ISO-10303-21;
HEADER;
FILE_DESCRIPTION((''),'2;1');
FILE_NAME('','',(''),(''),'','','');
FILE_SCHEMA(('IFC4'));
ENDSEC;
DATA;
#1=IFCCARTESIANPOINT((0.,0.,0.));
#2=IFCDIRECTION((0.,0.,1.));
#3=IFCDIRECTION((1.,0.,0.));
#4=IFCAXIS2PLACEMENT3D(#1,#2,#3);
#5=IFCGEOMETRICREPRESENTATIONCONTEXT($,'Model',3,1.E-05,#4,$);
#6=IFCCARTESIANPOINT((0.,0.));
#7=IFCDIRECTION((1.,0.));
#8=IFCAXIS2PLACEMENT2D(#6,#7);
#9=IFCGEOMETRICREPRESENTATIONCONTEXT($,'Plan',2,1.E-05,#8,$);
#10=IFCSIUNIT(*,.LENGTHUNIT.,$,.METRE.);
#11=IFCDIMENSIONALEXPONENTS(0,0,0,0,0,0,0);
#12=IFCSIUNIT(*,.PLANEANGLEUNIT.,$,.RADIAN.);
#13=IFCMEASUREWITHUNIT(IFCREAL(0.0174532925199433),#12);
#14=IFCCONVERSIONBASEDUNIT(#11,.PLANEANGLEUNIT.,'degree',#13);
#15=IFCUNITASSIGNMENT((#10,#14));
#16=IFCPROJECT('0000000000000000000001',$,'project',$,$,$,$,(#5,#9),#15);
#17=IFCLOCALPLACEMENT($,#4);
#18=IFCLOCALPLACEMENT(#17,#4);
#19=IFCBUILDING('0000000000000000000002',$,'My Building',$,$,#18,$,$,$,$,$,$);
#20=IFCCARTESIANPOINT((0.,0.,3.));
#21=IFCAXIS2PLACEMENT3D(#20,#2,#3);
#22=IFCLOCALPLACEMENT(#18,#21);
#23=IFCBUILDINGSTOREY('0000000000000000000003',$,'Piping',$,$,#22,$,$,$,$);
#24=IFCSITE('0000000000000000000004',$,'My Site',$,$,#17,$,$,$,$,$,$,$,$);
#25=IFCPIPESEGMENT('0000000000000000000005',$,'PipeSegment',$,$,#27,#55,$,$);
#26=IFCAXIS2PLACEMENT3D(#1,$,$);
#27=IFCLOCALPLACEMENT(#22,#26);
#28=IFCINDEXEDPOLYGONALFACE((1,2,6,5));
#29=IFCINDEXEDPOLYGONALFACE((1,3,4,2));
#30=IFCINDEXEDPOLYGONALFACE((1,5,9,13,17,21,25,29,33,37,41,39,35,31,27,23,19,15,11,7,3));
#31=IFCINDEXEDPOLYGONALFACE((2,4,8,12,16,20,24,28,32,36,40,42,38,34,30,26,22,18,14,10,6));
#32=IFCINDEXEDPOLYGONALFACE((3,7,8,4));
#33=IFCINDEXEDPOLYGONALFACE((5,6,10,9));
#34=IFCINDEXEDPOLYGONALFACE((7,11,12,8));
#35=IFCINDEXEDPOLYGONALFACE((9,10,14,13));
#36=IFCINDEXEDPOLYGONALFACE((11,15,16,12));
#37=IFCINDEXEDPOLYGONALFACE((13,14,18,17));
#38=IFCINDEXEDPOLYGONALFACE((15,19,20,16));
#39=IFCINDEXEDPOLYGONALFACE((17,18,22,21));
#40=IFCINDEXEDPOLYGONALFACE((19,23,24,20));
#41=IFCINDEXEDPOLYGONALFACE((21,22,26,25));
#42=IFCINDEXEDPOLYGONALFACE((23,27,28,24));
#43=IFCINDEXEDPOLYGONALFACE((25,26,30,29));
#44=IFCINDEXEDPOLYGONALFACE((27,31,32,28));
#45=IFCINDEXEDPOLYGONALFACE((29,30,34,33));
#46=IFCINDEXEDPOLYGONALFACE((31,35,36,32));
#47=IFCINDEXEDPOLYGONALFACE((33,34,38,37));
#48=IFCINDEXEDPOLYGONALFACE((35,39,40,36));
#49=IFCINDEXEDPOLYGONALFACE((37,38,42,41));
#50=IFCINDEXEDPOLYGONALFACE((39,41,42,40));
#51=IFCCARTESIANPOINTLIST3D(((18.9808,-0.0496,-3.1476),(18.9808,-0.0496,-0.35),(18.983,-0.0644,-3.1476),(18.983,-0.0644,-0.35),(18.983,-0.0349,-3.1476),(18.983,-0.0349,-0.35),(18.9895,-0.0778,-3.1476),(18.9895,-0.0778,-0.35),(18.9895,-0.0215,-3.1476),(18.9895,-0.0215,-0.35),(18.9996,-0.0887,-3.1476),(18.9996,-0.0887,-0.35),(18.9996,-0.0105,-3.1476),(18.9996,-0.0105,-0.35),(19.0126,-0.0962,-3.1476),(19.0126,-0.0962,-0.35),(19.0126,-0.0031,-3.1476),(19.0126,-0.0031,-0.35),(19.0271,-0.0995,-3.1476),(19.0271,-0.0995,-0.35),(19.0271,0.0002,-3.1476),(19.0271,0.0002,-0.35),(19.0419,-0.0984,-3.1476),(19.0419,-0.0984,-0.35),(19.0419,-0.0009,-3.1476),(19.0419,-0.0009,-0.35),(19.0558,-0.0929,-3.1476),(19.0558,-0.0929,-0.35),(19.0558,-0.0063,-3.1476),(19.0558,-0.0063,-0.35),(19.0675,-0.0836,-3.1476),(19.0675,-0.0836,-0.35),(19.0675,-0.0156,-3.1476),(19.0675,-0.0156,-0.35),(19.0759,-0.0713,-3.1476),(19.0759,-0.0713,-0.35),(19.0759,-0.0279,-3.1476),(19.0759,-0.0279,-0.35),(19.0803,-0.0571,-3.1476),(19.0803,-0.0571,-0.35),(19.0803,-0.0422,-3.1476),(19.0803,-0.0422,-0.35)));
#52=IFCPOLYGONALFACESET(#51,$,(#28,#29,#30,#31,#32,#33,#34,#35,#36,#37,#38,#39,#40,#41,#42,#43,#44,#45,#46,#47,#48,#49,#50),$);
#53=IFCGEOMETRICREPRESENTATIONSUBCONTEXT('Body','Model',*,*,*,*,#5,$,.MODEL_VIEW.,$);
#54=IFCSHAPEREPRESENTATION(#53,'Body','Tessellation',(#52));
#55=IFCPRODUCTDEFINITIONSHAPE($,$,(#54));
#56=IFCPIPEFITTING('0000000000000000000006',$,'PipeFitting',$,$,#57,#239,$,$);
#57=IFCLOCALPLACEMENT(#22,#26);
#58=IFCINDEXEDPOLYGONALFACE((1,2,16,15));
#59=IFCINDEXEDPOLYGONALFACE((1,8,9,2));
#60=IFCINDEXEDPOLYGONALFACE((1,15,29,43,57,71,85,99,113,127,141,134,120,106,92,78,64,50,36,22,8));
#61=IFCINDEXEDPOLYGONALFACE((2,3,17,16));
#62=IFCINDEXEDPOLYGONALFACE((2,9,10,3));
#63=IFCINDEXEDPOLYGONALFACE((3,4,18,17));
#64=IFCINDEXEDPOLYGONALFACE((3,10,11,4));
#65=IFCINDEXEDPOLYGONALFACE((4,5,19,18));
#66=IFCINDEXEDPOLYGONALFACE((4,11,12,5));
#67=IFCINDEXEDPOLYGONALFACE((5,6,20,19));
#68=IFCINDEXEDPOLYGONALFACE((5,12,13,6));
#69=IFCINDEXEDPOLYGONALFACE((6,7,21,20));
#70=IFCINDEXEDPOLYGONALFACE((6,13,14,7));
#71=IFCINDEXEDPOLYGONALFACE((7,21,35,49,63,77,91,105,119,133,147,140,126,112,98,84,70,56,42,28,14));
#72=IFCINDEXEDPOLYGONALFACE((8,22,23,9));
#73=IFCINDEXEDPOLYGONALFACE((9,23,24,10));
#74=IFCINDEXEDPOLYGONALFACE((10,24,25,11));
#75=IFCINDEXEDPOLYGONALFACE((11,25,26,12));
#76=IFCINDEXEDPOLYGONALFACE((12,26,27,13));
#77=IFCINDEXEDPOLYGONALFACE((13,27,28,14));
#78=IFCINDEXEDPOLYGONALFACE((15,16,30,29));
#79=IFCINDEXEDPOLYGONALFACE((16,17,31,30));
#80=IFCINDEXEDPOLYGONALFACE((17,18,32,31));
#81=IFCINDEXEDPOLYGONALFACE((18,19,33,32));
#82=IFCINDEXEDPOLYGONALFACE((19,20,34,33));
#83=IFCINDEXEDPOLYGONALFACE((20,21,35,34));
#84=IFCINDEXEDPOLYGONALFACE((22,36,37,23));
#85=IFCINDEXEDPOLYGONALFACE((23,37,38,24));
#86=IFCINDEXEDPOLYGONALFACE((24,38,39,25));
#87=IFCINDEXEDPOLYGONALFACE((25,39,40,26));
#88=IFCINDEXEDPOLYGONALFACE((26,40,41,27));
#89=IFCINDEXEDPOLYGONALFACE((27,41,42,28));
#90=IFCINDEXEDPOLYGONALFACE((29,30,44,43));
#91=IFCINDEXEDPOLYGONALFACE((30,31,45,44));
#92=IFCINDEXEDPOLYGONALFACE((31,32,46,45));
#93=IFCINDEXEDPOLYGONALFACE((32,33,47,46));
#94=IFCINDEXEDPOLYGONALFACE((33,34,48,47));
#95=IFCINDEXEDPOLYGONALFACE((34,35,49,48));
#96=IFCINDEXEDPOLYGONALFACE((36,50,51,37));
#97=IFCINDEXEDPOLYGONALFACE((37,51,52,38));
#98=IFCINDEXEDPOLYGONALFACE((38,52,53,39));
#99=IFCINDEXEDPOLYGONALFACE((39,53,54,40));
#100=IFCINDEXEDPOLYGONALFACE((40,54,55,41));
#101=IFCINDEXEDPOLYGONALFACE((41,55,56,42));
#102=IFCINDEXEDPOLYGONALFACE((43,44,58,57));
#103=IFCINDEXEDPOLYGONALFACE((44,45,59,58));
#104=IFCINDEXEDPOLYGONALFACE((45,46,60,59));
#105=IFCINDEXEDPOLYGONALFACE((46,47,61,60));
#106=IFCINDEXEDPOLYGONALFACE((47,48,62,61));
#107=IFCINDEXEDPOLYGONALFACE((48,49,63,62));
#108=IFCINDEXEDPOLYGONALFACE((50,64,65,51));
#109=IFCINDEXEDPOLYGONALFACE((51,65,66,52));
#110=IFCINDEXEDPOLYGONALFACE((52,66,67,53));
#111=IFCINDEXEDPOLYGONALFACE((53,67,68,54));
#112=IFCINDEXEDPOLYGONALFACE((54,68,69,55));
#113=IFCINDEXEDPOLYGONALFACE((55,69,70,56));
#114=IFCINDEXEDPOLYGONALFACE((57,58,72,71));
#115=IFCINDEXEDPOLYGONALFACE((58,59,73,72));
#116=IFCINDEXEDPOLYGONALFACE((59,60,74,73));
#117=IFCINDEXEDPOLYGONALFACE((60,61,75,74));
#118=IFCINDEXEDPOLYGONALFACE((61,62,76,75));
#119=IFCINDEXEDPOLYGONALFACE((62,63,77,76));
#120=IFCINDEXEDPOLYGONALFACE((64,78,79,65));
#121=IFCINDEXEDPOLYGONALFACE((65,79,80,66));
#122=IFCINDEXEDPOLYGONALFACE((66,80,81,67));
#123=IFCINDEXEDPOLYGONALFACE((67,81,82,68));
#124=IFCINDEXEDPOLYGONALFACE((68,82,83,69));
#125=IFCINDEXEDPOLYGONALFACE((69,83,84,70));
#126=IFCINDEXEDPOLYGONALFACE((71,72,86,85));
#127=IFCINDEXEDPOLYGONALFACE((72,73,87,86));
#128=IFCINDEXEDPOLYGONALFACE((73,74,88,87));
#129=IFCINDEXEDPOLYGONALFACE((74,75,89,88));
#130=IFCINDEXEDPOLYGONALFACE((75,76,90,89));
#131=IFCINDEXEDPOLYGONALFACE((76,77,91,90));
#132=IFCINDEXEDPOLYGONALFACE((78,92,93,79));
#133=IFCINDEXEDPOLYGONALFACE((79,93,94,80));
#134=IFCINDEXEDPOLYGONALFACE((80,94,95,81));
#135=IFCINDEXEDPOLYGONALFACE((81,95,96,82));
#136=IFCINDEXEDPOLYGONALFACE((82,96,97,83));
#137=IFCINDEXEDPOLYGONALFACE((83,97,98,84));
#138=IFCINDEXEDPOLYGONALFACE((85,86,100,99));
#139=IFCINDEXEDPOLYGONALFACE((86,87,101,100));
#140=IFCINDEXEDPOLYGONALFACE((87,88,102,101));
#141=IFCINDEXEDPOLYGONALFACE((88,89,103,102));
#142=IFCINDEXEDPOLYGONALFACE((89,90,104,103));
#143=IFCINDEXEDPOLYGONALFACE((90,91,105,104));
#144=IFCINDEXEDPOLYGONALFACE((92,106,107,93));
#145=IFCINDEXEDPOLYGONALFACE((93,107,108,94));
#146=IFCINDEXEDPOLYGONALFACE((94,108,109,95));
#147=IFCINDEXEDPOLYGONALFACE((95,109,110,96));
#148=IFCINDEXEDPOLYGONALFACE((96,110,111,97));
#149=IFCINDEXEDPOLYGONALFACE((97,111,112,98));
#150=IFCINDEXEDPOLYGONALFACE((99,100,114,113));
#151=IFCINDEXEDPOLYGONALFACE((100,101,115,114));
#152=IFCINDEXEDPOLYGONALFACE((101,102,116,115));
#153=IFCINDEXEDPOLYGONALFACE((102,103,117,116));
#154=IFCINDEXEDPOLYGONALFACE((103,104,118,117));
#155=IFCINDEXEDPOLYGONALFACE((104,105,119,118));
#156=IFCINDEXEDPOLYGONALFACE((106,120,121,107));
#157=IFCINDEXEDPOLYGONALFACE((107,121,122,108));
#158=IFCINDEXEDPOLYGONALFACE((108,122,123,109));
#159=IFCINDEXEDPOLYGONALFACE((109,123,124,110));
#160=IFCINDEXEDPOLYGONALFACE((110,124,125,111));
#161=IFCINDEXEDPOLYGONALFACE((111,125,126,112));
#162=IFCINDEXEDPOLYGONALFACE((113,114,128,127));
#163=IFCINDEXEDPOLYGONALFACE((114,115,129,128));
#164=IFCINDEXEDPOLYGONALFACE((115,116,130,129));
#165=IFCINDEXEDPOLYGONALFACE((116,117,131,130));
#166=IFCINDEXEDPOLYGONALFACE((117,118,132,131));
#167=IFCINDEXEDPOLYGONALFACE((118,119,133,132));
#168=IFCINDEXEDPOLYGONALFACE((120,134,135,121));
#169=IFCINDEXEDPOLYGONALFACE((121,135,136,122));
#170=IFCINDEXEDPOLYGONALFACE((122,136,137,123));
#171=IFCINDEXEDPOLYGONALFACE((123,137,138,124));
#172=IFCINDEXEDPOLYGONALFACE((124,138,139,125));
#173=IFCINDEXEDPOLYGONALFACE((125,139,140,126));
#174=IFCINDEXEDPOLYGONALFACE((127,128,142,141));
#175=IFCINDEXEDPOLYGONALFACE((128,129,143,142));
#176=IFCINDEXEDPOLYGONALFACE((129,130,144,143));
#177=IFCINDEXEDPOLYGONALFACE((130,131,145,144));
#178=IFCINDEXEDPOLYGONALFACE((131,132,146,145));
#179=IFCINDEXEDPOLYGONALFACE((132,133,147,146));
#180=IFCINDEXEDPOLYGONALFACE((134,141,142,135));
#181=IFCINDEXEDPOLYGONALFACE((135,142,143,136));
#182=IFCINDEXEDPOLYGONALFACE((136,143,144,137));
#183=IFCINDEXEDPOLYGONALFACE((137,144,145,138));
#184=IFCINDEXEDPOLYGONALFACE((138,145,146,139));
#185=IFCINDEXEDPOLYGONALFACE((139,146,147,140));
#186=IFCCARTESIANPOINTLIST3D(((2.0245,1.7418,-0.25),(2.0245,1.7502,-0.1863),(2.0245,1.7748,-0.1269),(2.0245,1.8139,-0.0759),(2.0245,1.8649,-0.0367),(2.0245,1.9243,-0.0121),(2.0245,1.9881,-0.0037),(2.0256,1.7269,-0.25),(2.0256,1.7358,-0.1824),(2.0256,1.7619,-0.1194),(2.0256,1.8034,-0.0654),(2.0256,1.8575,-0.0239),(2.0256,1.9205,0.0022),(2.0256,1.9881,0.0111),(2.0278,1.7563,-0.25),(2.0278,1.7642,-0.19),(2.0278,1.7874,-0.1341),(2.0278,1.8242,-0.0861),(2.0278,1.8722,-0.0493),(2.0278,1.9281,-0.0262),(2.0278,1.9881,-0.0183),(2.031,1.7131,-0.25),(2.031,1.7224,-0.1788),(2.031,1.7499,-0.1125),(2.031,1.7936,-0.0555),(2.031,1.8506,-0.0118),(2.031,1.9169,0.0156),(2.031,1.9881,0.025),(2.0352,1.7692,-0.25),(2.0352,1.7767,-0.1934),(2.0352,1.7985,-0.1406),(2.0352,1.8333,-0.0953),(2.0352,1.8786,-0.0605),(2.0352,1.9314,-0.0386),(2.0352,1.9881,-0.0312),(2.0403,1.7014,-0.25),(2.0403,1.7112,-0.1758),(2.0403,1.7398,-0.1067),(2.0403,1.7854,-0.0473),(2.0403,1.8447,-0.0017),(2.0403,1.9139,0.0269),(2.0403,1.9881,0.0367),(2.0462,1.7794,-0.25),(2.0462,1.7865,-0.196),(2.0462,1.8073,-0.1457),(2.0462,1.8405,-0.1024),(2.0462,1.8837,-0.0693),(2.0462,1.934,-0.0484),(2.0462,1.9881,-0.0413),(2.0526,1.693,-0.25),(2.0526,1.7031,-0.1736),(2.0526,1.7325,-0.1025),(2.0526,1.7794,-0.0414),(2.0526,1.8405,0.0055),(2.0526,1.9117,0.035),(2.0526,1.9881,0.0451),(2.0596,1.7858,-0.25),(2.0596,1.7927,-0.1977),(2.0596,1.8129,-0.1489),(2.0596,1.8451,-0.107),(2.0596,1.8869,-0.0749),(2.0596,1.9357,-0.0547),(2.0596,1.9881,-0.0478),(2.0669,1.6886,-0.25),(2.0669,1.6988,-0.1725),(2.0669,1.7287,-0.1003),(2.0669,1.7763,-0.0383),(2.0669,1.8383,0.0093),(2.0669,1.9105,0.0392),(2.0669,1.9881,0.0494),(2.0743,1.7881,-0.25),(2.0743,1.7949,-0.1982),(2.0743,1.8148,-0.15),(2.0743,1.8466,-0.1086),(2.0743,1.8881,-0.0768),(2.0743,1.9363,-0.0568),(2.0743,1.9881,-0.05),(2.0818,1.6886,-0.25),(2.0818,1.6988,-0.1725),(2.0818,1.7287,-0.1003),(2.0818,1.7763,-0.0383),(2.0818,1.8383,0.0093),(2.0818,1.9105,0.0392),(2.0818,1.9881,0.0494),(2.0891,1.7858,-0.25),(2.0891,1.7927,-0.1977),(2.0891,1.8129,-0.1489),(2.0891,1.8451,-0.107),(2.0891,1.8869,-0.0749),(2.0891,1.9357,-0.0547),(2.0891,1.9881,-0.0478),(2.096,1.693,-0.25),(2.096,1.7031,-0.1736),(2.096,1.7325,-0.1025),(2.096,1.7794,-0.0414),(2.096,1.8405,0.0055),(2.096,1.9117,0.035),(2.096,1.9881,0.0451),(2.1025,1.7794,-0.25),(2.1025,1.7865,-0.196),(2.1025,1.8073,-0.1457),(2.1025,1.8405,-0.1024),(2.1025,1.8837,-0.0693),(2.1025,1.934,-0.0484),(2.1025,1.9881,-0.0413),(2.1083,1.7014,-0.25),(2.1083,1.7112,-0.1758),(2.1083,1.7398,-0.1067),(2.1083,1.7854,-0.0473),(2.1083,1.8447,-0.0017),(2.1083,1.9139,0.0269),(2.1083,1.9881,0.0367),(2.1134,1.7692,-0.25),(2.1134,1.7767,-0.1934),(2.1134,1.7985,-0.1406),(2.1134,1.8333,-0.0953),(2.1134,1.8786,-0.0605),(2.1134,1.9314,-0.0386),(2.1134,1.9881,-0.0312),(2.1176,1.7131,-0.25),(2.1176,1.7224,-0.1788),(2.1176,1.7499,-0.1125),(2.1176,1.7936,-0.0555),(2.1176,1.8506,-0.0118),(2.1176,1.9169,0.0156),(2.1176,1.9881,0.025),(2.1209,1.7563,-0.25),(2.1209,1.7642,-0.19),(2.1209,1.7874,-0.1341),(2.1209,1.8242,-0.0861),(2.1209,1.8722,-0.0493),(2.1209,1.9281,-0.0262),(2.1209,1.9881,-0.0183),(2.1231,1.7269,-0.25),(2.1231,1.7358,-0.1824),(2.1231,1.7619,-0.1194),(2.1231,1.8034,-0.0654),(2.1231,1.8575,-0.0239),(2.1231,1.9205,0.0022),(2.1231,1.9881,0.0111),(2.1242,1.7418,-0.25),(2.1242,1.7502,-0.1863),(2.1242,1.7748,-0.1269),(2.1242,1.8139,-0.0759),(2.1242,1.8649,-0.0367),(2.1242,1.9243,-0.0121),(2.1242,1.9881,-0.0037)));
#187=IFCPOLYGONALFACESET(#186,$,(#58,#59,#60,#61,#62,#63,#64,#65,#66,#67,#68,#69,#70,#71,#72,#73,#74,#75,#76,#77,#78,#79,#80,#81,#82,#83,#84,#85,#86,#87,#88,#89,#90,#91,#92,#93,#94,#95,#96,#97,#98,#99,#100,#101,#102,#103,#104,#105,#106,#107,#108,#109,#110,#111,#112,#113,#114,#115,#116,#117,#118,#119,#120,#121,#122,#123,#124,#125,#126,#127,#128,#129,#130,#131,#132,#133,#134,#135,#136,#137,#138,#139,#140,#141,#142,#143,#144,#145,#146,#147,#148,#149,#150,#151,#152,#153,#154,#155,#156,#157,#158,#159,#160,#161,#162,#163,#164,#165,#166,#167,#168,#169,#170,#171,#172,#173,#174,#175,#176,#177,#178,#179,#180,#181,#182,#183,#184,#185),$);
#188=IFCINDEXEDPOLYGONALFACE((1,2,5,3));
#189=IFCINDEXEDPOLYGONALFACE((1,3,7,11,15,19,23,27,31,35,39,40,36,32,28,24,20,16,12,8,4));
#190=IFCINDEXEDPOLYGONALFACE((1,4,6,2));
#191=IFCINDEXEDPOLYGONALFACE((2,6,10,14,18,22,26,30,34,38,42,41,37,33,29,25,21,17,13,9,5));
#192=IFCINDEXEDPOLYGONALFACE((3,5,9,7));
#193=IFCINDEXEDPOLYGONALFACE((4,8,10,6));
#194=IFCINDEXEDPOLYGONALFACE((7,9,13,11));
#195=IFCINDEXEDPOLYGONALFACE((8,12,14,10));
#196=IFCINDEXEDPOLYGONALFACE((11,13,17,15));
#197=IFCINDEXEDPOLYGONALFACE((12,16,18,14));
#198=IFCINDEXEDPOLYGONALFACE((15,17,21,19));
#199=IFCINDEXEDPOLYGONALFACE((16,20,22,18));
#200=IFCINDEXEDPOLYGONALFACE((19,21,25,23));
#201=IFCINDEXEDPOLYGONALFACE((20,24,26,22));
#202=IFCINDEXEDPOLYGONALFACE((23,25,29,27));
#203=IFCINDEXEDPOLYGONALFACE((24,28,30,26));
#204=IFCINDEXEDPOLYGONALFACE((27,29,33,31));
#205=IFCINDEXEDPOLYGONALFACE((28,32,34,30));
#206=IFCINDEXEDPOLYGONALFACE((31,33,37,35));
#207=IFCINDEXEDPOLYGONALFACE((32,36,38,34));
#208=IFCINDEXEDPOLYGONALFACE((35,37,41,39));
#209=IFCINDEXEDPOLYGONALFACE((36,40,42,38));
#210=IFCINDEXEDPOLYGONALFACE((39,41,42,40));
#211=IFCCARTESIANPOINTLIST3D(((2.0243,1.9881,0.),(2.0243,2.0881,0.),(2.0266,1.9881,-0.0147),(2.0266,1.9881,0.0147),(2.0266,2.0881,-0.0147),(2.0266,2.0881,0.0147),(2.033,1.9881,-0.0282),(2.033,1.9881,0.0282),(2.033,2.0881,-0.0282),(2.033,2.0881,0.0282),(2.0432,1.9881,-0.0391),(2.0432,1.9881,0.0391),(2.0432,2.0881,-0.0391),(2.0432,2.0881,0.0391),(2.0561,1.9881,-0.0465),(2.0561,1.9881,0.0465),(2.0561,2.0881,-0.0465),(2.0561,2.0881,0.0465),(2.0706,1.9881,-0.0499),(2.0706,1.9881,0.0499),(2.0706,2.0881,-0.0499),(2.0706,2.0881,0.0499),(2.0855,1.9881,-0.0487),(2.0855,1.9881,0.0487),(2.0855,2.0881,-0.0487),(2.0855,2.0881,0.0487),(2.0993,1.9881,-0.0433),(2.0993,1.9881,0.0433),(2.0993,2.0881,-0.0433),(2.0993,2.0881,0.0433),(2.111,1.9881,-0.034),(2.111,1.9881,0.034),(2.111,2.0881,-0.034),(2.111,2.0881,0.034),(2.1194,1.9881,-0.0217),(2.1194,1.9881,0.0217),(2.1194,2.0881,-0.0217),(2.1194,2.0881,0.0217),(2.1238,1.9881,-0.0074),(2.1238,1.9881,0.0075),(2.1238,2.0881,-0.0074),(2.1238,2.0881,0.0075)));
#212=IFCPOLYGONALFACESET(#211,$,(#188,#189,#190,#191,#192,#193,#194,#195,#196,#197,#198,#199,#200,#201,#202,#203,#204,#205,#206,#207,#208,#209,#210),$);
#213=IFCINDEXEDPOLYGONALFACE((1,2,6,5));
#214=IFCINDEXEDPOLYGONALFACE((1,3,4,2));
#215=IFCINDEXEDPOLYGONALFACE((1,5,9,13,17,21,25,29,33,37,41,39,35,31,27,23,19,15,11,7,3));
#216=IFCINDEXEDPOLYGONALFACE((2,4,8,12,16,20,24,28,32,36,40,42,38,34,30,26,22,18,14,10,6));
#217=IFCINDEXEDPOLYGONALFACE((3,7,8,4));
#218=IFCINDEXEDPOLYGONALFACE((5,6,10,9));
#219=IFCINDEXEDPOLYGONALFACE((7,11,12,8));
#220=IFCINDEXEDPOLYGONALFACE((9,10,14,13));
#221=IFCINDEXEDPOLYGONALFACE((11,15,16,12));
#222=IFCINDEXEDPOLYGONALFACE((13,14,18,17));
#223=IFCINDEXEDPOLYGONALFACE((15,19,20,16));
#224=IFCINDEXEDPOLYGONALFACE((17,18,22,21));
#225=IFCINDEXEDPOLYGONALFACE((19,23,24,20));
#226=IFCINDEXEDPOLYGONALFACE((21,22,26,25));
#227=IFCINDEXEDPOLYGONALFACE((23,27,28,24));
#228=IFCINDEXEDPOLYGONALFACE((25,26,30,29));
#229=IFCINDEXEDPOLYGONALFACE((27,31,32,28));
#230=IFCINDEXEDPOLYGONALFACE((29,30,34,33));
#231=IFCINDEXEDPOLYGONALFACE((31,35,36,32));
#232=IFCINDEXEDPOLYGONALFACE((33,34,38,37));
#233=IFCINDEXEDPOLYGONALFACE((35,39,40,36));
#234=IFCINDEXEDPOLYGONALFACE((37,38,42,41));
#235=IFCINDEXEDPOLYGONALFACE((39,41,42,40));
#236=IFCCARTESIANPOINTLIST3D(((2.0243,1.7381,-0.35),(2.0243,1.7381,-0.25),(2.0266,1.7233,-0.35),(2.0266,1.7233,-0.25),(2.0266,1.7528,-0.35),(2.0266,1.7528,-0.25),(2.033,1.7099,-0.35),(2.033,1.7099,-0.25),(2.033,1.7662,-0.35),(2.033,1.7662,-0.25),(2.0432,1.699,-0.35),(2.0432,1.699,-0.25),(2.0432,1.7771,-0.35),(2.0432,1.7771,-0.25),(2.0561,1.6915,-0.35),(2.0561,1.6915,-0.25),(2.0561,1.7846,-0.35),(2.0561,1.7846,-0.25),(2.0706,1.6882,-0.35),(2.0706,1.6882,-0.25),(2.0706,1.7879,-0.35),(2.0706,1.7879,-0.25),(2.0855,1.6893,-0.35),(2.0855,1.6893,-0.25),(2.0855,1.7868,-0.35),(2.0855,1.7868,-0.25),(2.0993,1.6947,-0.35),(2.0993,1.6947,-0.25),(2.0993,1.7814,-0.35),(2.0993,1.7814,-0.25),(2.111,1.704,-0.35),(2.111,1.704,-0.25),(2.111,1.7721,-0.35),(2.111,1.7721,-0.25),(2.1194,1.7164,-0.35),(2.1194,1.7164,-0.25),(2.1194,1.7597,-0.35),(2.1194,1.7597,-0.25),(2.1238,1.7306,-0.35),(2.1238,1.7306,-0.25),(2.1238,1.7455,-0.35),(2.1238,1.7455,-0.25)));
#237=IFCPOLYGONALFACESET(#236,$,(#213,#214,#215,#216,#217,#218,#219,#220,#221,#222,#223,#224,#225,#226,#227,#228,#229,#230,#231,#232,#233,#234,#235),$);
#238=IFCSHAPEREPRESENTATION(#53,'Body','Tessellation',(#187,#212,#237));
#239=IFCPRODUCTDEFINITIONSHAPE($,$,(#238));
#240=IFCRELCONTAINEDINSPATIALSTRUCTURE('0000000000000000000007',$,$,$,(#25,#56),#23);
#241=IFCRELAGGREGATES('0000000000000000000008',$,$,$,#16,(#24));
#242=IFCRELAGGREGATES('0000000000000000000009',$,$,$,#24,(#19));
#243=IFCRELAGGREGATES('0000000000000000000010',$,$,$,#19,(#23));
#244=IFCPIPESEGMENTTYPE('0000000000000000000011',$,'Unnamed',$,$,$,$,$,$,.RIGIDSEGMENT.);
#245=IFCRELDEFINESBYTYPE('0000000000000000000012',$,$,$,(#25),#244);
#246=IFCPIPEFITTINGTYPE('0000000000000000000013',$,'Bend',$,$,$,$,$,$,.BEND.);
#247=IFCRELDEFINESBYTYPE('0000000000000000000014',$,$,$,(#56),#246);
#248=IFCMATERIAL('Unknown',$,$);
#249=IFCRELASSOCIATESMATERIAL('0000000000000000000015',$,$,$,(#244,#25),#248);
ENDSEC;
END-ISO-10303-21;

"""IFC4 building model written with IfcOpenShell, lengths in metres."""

from ifc_helpers import new_model, entity, si_unit, converted_unit, frame, origin_with_axes, origin_2d_with_axis, place, context, subcontext, project, spatial, circle, extrude, source, transform, mapped, material, material_profile, profile_set, profile_usage, type_object, type_shapes, element, save


model = new_model("IFC4")

# Units and contexts
model_context = context("Model", 3, precision=1e-05, world=origin_with_axes())
plan_context = context("Plan", 2, precision=1e-05, world=origin_2d_with_axis())
body_context = subcontext(model_context, "Body", "Model", "MODEL_VIEW")
ifc_project = project(units=[si_unit("LENGTHUNIT", "METRE"), converted_unit("PLANEANGLEUNIT", "degree", entity("IfcReal", 0.0174532925199433), si_unit("PLANEANGLEUNIT", "RADIAN"), dimensions=[0, 0, 0, 0, 0, 0, 0])], contexts=[model_context, plan_context])

# Site, building, storey
site_placement = place(None, origin_with_axes())
site = spatial("IfcSite", under=ifc_project, at=site_placement, Name="My Site")
building_placement = place(site_placement, origin_with_axes())
building = spatial("IfcBuilding", under=site, at=building_placement, Name="My Building")
storey_placement = place(building_placement, frame((0.0, 0.0, 3.0), z_axis=(0.0, 0.0, 1.0), x_axis=(1.0, 0.0, 0.0)))
storey = spatial("IfcBuildingStorey", under=building, at=storey_placement, Name="Piping")

# Pipe segment
ifc_material = material(Name="Unknown")
ifc_material_profile = material_profile(ifc_material, circle(Radius=0.05))
ifc_profile_set = profile_set([ifc_material_profile])
pipe_segment_type = type_object("IfcPipeSegmentType", Name="Unnamed", PredefinedType="RIGIDSEGMENT", material=ifc_profile_set)
ifc_profile_usage_1 = profile_usage(ifc_profile_set, cardinal=5)
pipe_segment_1_placement = place(storey_placement, frame((19.0308, -0.0496, -0.35), z_axis=(0.0, 0.0, -1.0), x_axis=(-1.0, 0.0, 0.0)))
element("IfcPipeSegment", 1, at=pipe_segment_1_placement, inside=storey, type_object=pipe_segment_type, material=ifc_profile_usage_1, Name="PipeSegment", context=body_context, shape_type="SweptSolid", body=[
    extrude(circle(Radius=0.05), origin_with_axes(), (0.0, 0.0, 1.0), 2.7976),
])

# Pipe fitting
pipe_fitting_type = type_object("IfcPipeFittingType", Name="Bend", PredefinedType="BEND")
shared_shape = source(origin_with_axes(), body_context, "Body", "SolidModel", [
    entity("IfcSweptDiskSolid", entity("IfcIndexedPolyCurve", entity("IfcCartesianPointList3D", [[0.0, 0.0, -0.1], [0.0, -0.0732, -0.2768], [0.0, -0.25, -0.35]]), [entity("IfcArcIndex", [1, 2, 3])]), 0.05),
    extrude(circle(Radius=0.05), origin_with_axes(), (0.0, 0.0, -1.0), 0.1),
    extrude(circle(Radius=0.05), frame((0.0, -0.25, -0.35), z_axis=(0.0, -1.0, 0.0), x_axis=(1.0, 0.0, 0.0)), (0.0, 0.0, 1.0), 0.1),
])
type_shapes(pipe_fitting_type, [shared_shape])
for number, where, z_axis, x_axis, name in (
    (2, (2.0743, 2.0881, 0.0), (0.0, 1.0, 0.0), (-1.0, 0.0, 0.0), "PipeFitting"),
):
    element("IfcPipeFitting", number, at=place(storey_placement, frame(where, z_axis=z_axis, x_axis=x_axis)), inside=storey, type_object=pipe_fitting_type, Name=name, context=body_context, shape_type="MappedRepresentation", body=[
        mapped(shared_shape, transform((0.0, 0.0, 0.0), x_axis=(1.0, 0.0, 0.0), y_axis=(0.0, 1.0, 0.0), z_axis=(0.0, 0.0, 1.0), scale=1.0)),
    ])

save(model, "model.ifc")
